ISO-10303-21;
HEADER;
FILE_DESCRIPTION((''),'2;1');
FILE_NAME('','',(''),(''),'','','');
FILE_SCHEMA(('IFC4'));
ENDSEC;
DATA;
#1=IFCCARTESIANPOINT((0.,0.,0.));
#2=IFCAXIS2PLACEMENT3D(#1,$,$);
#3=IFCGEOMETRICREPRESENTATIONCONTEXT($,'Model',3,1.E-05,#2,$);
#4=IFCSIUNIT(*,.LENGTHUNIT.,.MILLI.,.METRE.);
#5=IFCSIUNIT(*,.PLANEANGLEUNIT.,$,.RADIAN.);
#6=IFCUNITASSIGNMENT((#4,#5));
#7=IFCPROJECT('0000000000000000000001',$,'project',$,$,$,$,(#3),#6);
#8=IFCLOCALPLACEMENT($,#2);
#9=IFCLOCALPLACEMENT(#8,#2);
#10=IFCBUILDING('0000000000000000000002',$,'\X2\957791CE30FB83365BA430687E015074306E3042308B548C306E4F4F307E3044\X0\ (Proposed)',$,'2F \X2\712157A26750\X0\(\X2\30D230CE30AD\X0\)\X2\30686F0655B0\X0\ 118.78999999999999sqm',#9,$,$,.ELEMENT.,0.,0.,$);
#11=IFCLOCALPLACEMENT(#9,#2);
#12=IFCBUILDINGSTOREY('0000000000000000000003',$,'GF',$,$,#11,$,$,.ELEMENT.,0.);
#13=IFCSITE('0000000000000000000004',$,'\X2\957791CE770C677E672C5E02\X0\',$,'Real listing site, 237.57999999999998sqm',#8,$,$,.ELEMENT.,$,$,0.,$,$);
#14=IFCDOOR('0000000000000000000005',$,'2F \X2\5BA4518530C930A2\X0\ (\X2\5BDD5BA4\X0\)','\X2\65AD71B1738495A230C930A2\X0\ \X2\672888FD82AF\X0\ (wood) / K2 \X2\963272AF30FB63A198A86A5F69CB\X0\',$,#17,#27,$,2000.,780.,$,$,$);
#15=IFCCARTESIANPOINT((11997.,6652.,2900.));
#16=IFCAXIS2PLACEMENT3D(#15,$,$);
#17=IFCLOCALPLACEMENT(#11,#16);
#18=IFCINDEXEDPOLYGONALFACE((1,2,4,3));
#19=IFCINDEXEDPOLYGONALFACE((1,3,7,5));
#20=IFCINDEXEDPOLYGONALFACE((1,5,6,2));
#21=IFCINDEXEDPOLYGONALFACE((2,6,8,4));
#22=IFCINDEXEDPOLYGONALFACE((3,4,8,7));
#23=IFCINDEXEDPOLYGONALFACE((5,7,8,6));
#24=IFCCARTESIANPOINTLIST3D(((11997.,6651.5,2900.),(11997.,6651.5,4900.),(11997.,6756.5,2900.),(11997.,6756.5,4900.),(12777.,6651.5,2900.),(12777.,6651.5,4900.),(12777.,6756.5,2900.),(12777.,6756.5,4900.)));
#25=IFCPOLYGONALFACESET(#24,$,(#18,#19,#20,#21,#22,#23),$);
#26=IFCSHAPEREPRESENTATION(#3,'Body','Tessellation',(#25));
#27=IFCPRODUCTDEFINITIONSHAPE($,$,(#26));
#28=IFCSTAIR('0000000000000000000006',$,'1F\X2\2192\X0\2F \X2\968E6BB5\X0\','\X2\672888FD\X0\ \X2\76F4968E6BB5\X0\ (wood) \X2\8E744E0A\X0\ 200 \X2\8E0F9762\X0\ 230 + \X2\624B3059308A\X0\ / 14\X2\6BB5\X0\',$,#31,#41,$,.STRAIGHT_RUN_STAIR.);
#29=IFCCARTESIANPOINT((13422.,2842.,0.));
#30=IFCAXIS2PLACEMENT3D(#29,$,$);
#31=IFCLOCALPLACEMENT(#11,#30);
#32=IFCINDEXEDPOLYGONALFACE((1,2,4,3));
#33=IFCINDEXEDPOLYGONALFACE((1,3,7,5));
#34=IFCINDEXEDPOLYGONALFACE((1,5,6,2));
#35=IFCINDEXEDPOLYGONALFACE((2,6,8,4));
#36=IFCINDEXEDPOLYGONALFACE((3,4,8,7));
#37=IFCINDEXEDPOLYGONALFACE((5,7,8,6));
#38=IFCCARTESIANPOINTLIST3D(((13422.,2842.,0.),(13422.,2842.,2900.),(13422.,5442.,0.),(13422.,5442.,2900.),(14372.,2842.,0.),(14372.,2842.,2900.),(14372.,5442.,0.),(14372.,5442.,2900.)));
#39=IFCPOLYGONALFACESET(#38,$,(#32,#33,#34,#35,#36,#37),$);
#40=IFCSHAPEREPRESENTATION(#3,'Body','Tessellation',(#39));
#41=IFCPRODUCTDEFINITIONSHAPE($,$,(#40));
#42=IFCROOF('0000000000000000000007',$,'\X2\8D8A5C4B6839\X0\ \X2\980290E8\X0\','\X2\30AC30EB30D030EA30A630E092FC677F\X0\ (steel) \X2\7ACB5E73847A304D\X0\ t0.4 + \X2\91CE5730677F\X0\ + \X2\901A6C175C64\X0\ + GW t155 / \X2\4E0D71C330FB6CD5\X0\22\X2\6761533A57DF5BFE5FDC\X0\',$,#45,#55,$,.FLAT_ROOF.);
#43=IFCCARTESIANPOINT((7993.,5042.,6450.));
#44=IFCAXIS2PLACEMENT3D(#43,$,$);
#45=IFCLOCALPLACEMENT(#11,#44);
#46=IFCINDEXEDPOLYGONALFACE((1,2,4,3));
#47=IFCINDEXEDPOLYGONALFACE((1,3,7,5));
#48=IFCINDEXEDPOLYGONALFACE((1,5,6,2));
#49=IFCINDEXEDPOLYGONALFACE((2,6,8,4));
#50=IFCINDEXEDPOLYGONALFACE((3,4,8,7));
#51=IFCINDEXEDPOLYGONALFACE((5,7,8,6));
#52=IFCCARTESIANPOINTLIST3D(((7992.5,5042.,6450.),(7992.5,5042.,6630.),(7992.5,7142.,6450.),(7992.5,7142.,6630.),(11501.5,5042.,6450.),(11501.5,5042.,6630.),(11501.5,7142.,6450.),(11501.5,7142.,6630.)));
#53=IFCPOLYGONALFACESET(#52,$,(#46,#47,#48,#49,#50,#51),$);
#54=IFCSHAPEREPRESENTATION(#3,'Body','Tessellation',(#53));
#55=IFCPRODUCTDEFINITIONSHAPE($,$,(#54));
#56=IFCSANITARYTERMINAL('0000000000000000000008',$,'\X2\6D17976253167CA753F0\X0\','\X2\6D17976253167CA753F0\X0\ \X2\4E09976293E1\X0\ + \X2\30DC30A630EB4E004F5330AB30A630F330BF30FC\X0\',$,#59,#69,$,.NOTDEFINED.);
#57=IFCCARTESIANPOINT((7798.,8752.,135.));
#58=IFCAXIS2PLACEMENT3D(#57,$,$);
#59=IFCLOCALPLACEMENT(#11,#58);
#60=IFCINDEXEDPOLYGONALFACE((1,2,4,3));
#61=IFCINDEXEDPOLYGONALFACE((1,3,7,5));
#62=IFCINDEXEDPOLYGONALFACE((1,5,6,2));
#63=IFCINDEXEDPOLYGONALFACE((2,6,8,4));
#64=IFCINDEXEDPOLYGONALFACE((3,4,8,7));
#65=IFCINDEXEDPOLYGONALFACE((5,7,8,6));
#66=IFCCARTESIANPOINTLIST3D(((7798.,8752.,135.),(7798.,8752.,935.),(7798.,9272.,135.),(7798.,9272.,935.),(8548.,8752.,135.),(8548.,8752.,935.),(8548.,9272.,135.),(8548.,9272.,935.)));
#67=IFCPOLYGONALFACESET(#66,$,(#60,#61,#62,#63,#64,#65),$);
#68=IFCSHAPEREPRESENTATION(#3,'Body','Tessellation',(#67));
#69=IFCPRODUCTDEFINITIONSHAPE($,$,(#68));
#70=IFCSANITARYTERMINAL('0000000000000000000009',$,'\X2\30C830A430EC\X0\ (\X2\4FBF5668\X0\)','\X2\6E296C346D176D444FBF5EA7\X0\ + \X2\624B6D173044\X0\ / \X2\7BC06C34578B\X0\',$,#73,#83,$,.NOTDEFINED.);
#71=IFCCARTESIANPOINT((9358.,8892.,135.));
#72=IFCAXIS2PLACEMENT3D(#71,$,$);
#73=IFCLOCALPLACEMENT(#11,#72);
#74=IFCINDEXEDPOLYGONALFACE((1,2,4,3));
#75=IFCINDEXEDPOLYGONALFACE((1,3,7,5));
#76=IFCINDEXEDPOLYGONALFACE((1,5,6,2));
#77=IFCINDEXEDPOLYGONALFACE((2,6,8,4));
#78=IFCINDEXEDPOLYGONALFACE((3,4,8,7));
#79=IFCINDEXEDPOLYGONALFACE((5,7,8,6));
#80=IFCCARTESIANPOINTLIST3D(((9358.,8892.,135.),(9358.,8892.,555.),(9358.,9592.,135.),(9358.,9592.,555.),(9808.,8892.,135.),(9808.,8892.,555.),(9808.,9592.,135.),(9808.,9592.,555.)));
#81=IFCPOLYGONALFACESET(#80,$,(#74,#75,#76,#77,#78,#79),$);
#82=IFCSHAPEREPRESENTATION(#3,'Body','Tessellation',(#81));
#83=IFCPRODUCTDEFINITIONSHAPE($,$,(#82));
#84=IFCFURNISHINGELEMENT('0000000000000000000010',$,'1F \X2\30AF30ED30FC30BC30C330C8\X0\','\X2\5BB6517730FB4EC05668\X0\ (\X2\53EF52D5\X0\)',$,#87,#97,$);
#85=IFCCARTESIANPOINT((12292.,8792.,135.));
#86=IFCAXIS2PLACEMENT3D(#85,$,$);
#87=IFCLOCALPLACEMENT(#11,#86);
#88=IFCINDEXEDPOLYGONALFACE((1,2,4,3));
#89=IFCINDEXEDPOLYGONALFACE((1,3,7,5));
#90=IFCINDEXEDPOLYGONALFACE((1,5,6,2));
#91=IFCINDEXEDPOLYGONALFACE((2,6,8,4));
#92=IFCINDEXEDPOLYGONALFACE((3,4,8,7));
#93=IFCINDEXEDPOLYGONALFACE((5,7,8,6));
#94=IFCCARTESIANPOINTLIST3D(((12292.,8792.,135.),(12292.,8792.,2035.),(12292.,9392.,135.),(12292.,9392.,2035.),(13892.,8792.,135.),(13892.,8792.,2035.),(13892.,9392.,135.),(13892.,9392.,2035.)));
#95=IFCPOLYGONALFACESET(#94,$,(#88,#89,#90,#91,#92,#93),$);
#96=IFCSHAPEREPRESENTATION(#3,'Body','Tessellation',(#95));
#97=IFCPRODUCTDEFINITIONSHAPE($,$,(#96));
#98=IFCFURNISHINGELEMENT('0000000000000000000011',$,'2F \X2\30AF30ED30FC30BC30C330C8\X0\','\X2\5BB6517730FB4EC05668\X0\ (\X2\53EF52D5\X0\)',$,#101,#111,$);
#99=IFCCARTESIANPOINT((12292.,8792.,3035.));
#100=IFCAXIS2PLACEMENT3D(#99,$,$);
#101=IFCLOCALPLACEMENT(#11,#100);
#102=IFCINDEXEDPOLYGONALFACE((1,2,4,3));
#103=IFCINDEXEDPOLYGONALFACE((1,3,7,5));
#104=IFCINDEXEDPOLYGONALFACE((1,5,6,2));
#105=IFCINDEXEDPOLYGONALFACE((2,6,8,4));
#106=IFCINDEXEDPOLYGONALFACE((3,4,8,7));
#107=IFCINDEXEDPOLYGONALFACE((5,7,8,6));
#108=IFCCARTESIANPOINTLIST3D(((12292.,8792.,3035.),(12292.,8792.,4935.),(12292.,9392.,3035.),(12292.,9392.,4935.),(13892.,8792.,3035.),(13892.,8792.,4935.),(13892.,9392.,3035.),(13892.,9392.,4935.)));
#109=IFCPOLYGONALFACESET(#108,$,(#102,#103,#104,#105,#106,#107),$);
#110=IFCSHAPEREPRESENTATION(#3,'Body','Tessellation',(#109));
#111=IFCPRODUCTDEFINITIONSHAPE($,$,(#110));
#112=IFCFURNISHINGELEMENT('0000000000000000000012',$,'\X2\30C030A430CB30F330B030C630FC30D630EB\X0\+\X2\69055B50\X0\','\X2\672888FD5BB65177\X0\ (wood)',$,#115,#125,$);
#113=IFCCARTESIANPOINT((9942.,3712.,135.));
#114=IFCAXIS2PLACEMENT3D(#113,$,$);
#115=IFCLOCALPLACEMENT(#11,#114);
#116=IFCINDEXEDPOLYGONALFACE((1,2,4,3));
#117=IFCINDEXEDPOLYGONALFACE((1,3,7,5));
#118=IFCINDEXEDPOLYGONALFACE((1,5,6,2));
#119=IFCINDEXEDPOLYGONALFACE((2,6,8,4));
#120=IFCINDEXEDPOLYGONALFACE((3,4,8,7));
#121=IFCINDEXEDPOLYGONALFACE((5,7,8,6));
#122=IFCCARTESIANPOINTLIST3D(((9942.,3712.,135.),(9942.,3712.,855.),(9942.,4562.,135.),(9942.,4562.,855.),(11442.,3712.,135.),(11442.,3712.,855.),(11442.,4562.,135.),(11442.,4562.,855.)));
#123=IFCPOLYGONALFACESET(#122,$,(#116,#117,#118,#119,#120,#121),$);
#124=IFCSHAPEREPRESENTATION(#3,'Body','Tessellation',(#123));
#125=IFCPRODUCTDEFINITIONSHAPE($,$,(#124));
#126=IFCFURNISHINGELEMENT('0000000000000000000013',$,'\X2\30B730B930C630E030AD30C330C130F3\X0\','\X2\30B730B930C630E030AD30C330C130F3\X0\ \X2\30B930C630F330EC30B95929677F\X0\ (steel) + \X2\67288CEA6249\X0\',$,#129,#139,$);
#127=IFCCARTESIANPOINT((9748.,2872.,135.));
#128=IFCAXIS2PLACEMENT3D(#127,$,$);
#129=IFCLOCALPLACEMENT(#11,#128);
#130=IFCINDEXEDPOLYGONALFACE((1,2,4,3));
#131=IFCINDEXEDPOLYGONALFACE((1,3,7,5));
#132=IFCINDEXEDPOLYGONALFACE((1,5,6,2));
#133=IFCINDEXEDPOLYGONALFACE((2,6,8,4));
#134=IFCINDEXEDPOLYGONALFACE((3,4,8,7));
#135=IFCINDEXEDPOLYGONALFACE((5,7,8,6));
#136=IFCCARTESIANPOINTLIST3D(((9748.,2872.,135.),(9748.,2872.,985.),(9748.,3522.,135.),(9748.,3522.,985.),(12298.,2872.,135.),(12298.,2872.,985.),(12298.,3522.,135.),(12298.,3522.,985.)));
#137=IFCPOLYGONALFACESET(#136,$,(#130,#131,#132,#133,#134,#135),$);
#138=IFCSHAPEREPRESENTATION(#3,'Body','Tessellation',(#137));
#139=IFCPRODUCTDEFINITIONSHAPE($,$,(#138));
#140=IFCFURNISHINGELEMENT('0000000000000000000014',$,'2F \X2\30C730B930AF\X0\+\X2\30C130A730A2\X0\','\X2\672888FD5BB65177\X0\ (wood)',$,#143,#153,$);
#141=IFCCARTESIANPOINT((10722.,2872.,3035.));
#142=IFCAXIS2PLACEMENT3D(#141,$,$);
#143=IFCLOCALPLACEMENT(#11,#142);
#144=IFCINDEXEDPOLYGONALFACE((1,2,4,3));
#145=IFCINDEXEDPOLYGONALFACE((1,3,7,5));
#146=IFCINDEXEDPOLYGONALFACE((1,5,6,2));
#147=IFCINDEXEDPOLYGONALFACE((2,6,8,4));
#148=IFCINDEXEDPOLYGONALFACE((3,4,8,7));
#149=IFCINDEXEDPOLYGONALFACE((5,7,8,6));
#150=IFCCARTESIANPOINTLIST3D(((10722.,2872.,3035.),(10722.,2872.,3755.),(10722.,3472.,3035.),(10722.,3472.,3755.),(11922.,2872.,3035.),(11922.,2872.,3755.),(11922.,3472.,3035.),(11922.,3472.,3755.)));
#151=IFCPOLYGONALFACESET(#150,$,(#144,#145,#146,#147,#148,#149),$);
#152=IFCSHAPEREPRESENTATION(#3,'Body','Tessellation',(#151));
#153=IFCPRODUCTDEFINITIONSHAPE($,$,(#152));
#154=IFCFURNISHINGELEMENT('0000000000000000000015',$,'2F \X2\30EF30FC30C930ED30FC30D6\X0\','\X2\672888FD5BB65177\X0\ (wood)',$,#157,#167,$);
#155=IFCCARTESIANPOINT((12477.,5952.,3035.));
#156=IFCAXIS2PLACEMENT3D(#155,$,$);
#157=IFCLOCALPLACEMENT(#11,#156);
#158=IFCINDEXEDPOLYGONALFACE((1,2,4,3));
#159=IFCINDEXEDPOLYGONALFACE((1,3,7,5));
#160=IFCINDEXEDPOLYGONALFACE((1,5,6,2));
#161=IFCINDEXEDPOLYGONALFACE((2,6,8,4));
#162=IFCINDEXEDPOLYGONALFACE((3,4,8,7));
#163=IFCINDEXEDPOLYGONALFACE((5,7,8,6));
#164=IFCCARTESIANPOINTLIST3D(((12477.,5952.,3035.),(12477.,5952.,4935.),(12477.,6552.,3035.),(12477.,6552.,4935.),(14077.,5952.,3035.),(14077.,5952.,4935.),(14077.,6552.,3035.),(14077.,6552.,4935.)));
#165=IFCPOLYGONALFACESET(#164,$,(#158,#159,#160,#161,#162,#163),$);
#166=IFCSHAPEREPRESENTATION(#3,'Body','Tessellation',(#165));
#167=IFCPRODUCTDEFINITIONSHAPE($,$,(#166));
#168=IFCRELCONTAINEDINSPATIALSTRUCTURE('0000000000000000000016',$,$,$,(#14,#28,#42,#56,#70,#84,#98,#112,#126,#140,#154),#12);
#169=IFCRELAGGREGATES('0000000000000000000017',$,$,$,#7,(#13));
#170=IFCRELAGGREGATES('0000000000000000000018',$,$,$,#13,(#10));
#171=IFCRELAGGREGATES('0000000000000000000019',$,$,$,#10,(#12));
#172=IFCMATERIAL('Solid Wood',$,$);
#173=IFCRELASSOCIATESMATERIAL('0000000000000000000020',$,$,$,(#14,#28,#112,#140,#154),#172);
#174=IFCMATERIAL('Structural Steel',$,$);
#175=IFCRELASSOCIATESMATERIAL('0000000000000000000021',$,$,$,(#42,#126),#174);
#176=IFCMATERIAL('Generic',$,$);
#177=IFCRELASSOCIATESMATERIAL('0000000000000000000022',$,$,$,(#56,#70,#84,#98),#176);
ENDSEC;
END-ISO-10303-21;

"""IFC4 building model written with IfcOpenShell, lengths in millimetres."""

from ifc_helpers import new_model, si_unit, frame, frame_2d, origin, place, context, project, spatial, rectangle, extrude, material, element, save


model = new_model("IFC4")

# Units and contexts
model_context = context("Model", 3, precision=1e-05, world=origin())
ifc_project = project(units=[si_unit("LENGTHUNIT", "METRE", prefix="MILLI"), si_unit("PLANEANGLEUNIT", "RADIAN")], contexts=[model_context])

# Site, building, storey
site_placement = place(None, origin())
site = spatial("IfcSite", under=ifc_project, at=site_placement, Name="長野県松本市", ObjectType="Real listing site, 237.57999999999998sqm", CompositionType="ELEMENT", RefElevation=0.0)
building_placement = place(site_placement, origin())
building = spatial("IfcBuilding", under=site, at=building_placement, Name="長野・茶室と縁側のある和の住まい (Proposed)", ObjectType="2F 無垢材(ヒノキ)と漆喰 118.78999999999999sqm", CompositionType="ELEMENT", ElevationOfRefHeight=0.0, ElevationOfTerrain=0.0)
storey_placement = place(building_placement, origin())
storey = spatial("IfcBuildingStorey", under=building, at=storey_placement, Name="GF", CompositionType="ELEMENT", Elevation=0.0)

# Shared definitions
ifc_material_1 = material(Name="Solid Wood")

# Door
door_1_placement = place(storey_placement, frame((11997.0, 6652.0, 2900.0)))
element("IfcDoor", 1, at=door_1_placement, inside=storey, material=ifc_material_1, Name="2F 室内ドア (寝室)", Description="断熱玄関ドア 木製芯 (wood) / K2 防犯・採風機構", OverallHeight=2000.0, OverallWidth=780.0, context=model_context, shape_type="SweptSolid", body=[
    extrude(rectangle(XDim=780.0, YDim=105.0, at=frame_2d((390.0, 52.0))), frame((11997.0, 6652.0, 2900.0)), (0.0, 0.0, 1.0), 2000.0),
])

# Stair
stair_placement = place(storey_placement, frame((13422.0, 2842.0, 0.0)))
element("IfcStair", 2, at=stair_placement, inside=storey, material=ifc_material_1, Name="1F→2F 階段", Description="木製 直階段 (wood) 蹴上 200 踏面 230 + 手すり / 14段", PredefinedType="STRAIGHT_RUN_STAIR", context=model_context, shape_type="SweptSolid", body=[
    extrude(rectangle(XDim=950.0, YDim=2600.0, at=frame_2d((475.0, 1300.0))), frame((13422.0, 2842.0, 0.0)), (0.0, 0.0, 1.0), 2900.0),
])

# Roof
ifc_material_2 = material(Name="Structural Steel")
roof_placement = place(storey_placement, frame((7993.0, 5042.0, 6450.0)))
element("IfcRoof", 3, at=roof_placement, inside=storey, material=ifc_material_2, Name="越屋根 頂部", Description="ガルバリウム鋼板 (steel) 立平葺き t0.4 + 野地板 + 通気層 + GW t155 / 不燃・法22条区域対応", PredefinedType="FLAT_ROOF", context=model_context, shape_type="SweptSolid", body=[
    extrude(rectangle(XDim=3509.0, YDim=2100.0, at=frame_2d((1754.0, 1050.0))), frame((7993.0, 5042.0, 6450.0)), (0.0, 0.0, 1.0), 180.0),
])

# Sanitary terminals
ifc_material_3 = material(Name="Generic")
sanitary_terminal_1_placement = place(storey_placement, frame((7798.0, 8752.0, 135.0)))
element("IfcSanitaryTerminal", 4, at=sanitary_terminal_1_placement, inside=storey, material=ifc_material_3, Name="洗面化粧台", Description="洗面化粧台 三面鏡 + ボウル一体カウンター", PredefinedType="NOTDEFINED", context=model_context, shape_type="SweptSolid", body=[
    extrude(rectangle(XDim=750.0, YDim=520.0, at=frame_2d((375.0, 260.0))), frame((7798.0, 8752.0, 135.0)), (0.0, 0.0, 1.0), 800.0),
])
sanitary_terminal_2_placement = place(storey_placement, frame((9358.0, 8892.0, 135.0)))
element("IfcSanitaryTerminal", 5, at=sanitary_terminal_2_placement, inside=storey, material=ifc_material_3, Name="トイレ (便器)", Description="温水洗浄便座 + 手洗い / 節水型", PredefinedType="NOTDEFINED", context=model_context, shape_type="SweptSolid", body=[
    extrude(rectangle(XDim=450.0, YDim=700.0, at=frame_2d((225.0, 350.0))), frame((9358.0, 8892.0, 135.0)), (0.0, 0.0, 1.0), 420.0),
])

# Furnishing elements
furnishing_1_placement = place(storey_placement, frame((12292.0, 8792.0, 135.0)))
element("IfcFurnishingElement", 6, at=furnishing_1_placement, inside=storey, material=ifc_material_3, Name="1F クローゼット", Description="家具・什器 (可動)", context=model_context, shape_type="SweptSolid", body=[
    extrude(rectangle(XDim=1600.0, YDim=600.0, at=frame_2d((800.0, 300.0))), frame((12292.0, 8792.0, 135.0)), (0.0, 0.0, 1.0), 1900.0),
])
furnishing_2_placement = place(storey_placement, frame((12292.0, 8792.0, 3035.0)))
element("IfcFurnishingElement", 7, at=furnishing_2_placement, inside=storey, material=ifc_material_3, Name="2F クローゼット", Description="家具・什器 (可動)", context=model_context, shape_type="SweptSolid", body=[
    extrude(rectangle(XDim=1600.0, YDim=600.0, at=frame_2d((800.0, 300.0))), frame((12292.0, 8792.0, 3035.0)), (0.0, 0.0, 1.0), 1900.0),
])
furnishing_3_placement = place(storey_placement, frame((9942.0, 3712.0, 135.0)))
element("IfcFurnishingElement", 8, at=furnishing_3_placement, inside=storey, material=ifc_material_1, Name="ダイニングテーブル+椅子", Description="木製家具 (wood)", context=model_context, shape_type="SweptSolid", body=[
    extrude(rectangle(XDim=1500.0, YDim=850.0, at=frame_2d((750.0, 425.0))), frame((9942.0, 3712.0, 135.0)), (0.0, 0.0, 1.0), 720.0),
])
furnishing_4_placement = place(storey_placement, frame((9748.0, 2872.0, 135.0)))
element("IfcFurnishingElement", 9, at=furnishing_4_placement, inside=storey, material=ifc_material_2, Name="システムキッチン", Description="システムキッチン ステンレス天板 (steel) + 木質扉", context=model_context, shape_type="SweptSolid", body=[
    extrude(rectangle(XDim=2550.0, YDim=650.0, at=frame_2d((1275.0, 325.0))), frame((9748.0, 2872.0, 135.0)), (0.0, 0.0, 1.0), 850.0),
])
furnishing_5_placement = place(storey_placement, frame((10722.0, 2872.0, 3035.0)))
element("IfcFurnishingElement", 10, at=furnishing_5_placement, inside=storey, material=ifc_material_1, Name="2F デスク+チェア", Description="木製家具 (wood)", context=model_context, shape_type="SweptSolid", body=[
    extrude(rectangle(XDim=1200.0, YDim=600.0, at=frame_2d((600.0, 300.0))), frame((10722.0, 2872.0, 3035.0)), (0.0, 0.0, 1.0), 720.0),
])
furnishing_6_placement = place(storey_placement, frame((12477.0, 5952.0, 3035.0)))
element("IfcFurnishingElement", 11, at=furnishing_6_placement, inside=storey, material=ifc_material_1, Name="2F ワードローブ", Description="木製家具 (wood)", context=model_context, shape_type="SweptSolid", body=[
    extrude(rectangle(XDim=1600.0, YDim=600.0, at=frame_2d((800.0, 300.0))), frame((12477.0, 5952.0, 3035.0)), (0.0, 0.0, 1.0), 1900.0),
])

save(model, "model.ifc")
